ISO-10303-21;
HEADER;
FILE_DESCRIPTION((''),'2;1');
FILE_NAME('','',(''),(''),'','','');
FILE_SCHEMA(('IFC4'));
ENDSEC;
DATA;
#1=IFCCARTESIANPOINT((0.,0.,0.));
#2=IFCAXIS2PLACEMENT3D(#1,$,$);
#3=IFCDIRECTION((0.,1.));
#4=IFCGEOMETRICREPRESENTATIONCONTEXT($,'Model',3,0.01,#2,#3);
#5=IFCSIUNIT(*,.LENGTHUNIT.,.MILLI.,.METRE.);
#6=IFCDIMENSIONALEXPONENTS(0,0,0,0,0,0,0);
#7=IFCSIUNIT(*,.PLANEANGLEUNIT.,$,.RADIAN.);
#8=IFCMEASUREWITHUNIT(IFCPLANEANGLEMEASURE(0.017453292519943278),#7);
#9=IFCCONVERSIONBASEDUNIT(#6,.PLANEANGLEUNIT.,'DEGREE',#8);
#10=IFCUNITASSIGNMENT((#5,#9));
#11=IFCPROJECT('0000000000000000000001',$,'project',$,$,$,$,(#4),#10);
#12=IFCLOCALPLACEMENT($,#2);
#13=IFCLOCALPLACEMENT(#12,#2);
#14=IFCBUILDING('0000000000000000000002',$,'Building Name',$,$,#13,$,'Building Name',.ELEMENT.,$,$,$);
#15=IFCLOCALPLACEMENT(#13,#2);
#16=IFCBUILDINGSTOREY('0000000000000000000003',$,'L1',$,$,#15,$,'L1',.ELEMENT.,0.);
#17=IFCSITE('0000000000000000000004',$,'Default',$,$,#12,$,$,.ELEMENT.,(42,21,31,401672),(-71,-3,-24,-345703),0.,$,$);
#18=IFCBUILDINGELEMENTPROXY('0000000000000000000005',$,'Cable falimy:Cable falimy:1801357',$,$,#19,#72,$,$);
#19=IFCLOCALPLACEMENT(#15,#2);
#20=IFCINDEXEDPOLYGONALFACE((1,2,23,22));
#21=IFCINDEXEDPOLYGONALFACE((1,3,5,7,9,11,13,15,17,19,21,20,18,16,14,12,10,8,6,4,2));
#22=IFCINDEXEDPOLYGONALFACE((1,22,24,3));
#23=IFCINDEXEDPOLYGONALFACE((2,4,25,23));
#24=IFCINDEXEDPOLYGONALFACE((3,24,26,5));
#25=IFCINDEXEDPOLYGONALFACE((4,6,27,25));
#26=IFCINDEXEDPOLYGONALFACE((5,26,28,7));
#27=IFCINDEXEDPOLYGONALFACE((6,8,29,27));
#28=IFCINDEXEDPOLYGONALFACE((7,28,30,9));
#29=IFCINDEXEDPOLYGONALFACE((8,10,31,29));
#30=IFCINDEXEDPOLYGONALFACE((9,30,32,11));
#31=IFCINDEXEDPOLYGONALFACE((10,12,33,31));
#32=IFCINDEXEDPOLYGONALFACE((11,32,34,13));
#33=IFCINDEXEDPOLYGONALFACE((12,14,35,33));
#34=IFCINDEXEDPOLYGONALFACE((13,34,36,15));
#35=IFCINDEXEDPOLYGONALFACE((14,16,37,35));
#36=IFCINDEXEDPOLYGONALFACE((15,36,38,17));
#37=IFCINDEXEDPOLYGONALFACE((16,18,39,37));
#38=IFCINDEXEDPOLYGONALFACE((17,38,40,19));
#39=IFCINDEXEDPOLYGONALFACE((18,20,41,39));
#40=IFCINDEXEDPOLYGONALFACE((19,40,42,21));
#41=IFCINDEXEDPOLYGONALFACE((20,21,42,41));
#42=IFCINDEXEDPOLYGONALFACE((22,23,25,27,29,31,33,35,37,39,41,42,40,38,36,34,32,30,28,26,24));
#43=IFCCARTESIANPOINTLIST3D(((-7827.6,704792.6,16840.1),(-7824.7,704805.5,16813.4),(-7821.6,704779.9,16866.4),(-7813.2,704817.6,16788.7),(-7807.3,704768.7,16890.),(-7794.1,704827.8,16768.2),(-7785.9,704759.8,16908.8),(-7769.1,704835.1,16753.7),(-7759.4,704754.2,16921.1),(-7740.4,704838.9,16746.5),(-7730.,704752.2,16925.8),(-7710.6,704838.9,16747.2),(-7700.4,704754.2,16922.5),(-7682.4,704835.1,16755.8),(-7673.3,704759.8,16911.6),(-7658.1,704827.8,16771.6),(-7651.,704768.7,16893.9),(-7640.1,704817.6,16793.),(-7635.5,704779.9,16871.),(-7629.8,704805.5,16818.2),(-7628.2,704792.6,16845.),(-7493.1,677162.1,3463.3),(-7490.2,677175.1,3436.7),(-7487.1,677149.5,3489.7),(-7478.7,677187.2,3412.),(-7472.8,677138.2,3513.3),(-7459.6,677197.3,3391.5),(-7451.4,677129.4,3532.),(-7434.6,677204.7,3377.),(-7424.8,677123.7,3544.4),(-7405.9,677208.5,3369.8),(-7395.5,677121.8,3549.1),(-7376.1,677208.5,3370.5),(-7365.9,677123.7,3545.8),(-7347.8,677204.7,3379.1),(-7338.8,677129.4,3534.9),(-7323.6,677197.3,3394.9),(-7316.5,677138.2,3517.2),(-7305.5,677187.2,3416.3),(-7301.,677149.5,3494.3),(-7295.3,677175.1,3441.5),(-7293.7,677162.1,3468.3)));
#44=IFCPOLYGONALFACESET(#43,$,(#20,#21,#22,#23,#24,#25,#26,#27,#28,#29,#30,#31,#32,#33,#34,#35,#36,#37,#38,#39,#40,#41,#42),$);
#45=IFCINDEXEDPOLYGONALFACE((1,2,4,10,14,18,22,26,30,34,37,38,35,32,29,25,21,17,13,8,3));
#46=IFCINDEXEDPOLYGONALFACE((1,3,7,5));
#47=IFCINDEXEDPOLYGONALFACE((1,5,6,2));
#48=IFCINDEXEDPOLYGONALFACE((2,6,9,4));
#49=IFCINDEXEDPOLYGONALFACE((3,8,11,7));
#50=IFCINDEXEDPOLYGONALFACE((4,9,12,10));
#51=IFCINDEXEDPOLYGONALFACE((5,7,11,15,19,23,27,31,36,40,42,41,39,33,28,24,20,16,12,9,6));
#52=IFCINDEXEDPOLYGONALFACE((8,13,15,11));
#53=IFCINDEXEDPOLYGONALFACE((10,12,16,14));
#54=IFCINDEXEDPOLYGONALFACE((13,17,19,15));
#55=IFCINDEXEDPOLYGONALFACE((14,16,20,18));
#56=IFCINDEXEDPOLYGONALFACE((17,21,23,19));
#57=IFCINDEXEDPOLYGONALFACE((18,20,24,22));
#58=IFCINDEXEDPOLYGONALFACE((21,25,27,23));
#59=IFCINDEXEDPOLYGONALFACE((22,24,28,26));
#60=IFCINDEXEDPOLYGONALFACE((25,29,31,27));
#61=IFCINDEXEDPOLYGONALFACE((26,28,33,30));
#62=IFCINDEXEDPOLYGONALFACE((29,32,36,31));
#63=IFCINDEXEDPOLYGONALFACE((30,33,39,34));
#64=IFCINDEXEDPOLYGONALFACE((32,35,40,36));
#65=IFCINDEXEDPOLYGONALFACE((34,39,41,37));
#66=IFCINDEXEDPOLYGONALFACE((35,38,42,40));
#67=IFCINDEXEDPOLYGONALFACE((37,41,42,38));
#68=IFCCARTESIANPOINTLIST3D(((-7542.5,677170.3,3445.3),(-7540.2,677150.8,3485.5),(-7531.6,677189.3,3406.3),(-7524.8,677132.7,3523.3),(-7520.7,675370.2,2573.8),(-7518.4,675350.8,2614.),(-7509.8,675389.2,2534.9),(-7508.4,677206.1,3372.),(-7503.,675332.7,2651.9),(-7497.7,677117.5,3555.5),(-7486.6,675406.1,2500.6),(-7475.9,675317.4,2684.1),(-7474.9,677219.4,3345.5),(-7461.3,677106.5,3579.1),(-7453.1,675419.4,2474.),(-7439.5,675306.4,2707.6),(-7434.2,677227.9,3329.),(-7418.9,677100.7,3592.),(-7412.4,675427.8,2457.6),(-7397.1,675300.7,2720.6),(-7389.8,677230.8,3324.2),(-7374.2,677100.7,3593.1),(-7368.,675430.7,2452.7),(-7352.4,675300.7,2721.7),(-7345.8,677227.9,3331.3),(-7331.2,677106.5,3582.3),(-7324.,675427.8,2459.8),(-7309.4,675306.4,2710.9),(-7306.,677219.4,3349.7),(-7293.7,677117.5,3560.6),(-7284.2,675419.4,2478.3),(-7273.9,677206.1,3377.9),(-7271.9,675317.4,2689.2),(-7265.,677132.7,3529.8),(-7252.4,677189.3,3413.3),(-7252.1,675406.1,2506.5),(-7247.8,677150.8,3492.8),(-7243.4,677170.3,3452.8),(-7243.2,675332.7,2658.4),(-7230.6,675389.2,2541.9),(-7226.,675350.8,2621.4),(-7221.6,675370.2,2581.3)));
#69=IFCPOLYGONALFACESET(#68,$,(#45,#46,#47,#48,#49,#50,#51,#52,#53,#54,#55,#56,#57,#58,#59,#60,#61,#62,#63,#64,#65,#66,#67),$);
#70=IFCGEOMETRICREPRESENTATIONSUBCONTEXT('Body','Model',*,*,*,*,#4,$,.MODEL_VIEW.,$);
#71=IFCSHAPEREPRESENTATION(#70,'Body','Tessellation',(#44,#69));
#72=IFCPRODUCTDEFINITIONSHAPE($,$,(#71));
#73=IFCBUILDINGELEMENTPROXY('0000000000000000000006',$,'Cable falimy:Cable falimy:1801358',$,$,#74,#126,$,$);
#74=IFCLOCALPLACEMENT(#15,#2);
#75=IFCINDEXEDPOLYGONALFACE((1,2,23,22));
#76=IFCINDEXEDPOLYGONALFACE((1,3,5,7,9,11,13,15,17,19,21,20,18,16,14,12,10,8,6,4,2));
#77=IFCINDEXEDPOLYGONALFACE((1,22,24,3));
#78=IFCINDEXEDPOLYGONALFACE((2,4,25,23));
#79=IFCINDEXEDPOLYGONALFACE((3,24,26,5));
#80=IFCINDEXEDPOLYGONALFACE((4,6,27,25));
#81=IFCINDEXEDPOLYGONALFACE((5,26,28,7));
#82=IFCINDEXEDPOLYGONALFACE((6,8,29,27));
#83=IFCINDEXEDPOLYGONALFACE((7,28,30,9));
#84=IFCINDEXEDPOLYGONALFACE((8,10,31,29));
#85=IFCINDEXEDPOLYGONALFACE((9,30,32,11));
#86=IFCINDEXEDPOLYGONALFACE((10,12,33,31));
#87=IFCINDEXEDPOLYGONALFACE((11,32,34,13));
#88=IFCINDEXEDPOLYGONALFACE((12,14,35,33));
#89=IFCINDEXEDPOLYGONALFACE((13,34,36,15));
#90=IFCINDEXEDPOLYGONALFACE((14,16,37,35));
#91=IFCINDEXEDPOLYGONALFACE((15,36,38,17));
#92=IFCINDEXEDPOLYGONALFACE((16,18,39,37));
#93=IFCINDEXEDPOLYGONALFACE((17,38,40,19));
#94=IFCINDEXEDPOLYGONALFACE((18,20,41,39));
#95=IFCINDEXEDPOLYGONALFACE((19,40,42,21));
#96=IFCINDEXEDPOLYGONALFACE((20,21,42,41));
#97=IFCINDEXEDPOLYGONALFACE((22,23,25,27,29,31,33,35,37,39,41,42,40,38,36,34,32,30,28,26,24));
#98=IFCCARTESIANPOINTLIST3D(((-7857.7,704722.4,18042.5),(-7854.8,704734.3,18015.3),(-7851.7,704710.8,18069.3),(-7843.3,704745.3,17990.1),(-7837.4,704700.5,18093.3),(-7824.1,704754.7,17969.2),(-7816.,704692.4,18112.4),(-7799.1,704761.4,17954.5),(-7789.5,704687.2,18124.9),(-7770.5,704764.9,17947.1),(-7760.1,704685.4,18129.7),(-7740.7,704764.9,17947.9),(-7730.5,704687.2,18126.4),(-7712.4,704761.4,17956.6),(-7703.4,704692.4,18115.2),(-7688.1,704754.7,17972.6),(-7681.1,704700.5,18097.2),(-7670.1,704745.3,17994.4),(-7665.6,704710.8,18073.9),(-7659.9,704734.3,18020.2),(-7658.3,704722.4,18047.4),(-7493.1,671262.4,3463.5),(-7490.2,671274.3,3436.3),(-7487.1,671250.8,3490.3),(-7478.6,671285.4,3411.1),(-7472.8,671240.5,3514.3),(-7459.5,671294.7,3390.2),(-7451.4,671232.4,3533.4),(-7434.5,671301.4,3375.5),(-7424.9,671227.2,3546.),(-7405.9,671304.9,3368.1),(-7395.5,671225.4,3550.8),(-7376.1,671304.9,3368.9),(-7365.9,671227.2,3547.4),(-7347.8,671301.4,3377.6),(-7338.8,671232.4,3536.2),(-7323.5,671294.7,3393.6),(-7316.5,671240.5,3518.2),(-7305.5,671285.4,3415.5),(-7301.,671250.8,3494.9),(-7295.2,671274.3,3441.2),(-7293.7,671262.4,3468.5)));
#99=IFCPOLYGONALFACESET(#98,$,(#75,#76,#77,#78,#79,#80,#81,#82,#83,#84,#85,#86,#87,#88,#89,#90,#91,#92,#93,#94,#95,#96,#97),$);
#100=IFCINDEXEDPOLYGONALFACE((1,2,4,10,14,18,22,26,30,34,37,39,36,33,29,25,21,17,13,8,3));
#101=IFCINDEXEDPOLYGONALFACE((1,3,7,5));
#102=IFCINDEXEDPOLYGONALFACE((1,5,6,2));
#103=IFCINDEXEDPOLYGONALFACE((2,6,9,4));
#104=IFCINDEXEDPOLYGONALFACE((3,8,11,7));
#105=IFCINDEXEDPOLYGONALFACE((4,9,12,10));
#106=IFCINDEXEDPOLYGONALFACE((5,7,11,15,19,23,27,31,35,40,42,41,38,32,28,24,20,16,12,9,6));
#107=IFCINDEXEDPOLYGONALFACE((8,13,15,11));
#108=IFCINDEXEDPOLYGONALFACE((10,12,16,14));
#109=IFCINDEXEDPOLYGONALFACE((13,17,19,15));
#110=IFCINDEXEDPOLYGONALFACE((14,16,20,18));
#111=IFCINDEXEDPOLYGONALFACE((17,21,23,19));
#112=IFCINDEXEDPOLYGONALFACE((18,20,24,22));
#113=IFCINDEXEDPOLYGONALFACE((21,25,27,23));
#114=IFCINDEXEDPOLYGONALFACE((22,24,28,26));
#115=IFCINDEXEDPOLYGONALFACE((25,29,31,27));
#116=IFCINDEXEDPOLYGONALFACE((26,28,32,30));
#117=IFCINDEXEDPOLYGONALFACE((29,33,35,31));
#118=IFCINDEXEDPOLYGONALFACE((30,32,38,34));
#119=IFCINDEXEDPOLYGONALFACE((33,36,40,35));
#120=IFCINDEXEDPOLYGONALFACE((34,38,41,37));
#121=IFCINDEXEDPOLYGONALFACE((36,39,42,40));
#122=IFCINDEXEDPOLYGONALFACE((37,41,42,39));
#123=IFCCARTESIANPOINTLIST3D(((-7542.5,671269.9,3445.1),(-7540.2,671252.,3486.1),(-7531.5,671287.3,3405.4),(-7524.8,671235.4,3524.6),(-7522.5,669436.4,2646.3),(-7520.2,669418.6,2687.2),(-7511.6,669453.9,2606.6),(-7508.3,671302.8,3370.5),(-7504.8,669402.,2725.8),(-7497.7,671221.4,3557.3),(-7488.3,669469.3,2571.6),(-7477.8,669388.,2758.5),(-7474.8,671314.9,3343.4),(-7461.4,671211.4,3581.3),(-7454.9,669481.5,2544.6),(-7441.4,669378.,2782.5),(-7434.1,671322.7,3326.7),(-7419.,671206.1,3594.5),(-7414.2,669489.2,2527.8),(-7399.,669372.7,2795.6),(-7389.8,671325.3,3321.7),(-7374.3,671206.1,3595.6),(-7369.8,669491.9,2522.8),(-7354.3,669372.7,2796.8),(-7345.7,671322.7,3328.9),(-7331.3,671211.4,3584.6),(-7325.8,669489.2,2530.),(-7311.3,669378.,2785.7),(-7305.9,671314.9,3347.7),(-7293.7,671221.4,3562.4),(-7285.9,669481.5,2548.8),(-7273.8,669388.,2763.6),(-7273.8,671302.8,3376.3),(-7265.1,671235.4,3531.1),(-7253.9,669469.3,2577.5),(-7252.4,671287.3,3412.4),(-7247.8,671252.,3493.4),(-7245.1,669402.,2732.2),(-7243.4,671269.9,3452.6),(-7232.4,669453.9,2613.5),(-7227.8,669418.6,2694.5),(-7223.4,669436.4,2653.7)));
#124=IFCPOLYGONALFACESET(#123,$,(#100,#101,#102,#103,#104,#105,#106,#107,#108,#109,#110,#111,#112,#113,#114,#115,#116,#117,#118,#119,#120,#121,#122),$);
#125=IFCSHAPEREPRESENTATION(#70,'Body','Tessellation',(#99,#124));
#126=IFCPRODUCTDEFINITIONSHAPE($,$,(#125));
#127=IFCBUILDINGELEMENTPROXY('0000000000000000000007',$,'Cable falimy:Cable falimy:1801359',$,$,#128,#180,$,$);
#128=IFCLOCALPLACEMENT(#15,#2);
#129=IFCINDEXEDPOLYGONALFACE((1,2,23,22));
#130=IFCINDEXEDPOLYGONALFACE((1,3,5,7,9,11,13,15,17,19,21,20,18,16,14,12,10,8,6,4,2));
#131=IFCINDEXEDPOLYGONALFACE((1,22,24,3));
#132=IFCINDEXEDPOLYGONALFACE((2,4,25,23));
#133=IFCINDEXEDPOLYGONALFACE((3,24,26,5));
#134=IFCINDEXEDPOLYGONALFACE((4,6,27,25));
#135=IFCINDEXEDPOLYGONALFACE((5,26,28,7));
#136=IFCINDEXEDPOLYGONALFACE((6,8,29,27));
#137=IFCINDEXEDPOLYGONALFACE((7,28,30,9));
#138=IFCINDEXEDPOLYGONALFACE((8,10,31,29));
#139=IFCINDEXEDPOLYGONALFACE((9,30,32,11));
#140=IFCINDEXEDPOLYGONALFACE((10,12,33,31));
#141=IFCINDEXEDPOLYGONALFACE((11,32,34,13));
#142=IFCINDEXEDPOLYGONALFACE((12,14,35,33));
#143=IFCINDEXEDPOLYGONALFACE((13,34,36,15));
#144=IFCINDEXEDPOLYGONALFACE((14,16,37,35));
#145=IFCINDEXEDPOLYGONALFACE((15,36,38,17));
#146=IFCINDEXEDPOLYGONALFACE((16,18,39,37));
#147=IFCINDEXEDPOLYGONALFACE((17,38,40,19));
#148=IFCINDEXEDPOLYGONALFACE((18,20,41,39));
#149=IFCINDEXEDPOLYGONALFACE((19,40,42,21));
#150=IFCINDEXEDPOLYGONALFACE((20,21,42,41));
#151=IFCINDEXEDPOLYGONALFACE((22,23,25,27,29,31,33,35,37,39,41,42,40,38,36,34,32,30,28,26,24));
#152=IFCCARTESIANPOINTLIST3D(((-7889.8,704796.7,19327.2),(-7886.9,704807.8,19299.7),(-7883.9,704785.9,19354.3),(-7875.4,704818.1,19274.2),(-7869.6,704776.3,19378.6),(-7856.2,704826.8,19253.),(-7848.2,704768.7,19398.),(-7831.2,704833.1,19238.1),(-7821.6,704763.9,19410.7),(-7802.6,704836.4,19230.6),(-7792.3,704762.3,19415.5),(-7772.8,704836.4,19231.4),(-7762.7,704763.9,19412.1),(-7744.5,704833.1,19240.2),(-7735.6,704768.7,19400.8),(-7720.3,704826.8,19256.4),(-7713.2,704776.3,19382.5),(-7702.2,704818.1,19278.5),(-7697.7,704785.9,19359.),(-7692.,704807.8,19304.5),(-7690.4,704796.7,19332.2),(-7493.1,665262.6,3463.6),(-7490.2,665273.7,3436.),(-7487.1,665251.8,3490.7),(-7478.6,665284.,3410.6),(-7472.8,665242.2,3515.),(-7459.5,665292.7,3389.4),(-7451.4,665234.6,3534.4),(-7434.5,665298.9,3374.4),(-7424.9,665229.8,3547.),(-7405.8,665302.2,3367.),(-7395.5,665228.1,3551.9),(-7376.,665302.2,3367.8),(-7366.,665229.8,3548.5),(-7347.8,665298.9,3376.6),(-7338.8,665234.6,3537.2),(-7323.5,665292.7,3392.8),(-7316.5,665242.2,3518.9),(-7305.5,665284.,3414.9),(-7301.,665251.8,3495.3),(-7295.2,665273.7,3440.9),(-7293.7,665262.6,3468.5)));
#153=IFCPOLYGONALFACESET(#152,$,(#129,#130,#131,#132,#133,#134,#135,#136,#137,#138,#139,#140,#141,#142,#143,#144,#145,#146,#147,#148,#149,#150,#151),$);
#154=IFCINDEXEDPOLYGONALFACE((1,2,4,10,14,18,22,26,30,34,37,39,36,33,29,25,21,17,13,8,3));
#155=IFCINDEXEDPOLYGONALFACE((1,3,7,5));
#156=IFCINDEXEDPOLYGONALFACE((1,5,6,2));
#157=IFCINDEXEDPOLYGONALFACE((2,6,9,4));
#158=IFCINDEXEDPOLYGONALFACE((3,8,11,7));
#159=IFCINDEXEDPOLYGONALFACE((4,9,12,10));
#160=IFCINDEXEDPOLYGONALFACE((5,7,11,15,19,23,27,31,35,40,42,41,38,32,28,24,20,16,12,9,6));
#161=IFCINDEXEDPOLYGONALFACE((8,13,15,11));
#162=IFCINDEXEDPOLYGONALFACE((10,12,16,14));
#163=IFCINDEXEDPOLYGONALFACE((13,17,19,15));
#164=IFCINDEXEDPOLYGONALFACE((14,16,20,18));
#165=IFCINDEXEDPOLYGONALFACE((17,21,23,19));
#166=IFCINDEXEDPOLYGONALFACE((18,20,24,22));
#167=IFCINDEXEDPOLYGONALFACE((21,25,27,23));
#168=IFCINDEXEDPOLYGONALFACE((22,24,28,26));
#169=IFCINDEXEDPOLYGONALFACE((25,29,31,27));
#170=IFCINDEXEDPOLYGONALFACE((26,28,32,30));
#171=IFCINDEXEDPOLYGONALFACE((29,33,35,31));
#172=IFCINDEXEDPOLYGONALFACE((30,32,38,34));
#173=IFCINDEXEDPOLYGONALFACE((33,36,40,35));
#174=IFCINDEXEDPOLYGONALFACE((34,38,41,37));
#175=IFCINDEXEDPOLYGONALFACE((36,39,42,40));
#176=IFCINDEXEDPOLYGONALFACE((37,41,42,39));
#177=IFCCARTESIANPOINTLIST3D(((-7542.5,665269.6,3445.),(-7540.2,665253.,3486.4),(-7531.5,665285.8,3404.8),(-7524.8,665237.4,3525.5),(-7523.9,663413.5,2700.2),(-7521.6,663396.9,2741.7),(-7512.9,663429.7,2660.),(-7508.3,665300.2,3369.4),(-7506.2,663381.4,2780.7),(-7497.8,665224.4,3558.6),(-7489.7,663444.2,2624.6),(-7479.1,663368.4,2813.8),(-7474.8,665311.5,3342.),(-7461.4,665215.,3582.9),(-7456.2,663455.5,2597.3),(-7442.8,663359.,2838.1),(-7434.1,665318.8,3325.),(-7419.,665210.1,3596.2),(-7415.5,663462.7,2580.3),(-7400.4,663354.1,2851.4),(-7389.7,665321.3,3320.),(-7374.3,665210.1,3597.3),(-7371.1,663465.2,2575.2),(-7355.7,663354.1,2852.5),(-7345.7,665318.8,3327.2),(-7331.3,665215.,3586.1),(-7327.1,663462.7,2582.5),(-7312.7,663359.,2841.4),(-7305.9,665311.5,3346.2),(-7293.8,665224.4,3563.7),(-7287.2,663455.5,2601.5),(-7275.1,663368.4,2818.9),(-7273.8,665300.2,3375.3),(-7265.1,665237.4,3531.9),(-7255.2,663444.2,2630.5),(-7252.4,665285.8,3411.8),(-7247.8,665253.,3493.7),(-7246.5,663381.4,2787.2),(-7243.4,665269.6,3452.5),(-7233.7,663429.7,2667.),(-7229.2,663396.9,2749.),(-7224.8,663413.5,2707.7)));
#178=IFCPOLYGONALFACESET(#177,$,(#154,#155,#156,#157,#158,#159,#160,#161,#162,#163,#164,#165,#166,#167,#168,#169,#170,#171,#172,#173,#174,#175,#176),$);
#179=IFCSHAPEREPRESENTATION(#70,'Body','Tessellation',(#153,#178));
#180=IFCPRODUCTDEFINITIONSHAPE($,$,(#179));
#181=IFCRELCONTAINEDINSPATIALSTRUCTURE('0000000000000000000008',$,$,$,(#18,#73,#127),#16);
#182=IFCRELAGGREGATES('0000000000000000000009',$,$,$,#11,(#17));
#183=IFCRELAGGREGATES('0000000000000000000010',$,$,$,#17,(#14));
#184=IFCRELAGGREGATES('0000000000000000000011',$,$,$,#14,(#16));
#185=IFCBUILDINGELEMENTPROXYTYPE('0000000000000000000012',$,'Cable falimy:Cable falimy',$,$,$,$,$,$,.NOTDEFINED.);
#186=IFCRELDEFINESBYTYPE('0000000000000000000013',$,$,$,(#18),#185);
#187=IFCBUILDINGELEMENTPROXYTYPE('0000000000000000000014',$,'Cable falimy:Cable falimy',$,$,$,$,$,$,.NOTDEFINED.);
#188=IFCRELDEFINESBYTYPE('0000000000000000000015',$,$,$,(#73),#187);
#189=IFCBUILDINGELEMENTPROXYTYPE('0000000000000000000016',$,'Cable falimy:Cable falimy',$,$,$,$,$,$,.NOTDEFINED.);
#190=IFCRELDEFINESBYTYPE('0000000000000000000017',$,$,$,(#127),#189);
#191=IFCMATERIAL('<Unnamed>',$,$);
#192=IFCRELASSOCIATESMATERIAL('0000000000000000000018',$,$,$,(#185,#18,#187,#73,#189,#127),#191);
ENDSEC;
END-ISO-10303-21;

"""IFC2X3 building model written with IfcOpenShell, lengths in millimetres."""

from ifc_helpers import new_model, entity, si_unit, converted_unit, direction, frame, frame_2d, origin, place, context, subcontext, project, spatial, circle, extrude, source, transform, mapped, material, type_object, type_shapes, element, save


model = new_model("IFC2X3")

# Units and contexts
model_context = context("Model", 3, precision=0.01, world=origin(), true_north=direction((0.0, 1.0)))
body_context = subcontext(model_context, "Body", "Model", "MODEL_VIEW")
ifc_project = project(units=[si_unit("LENGTHUNIT", "METRE", prefix="MILLI"), converted_unit("PLANEANGLEUNIT", "DEGREE", entity("IfcPlaneAngleMeasure", 0.017453292519943278), si_unit("PLANEANGLEUNIT", "RADIAN"), dimensions=[0, 0, 0, 0, 0, 0, 0])], contexts=[model_context])

# Site, building, storey
site_placement = place(None, origin())
site = spatial("IfcSite", under=ifc_project, at=site_placement, Name="Default", CompositionType="ELEMENT", RefLatitude=(42, 21, 31, 401672), RefLongitude=(-71, -3, -24, -345703), RefElevation=0.0)
building_placement = place(site_placement, origin())
building = spatial("IfcBuilding", under=site, at=building_placement, Name="Building Name", LongName="Building Name", CompositionType="ELEMENT")
storey_placement = place(building_placement, origin())
storey = spatial("IfcBuildingStorey", under=building, at=storey_placement, Name="L1", LongName="L1", CompositionType="ELEMENT", Elevation=0.0)

# Shared definitions
ifc_material = material(Name="<Unnamed>")

# Building element proxies
building_element_proxy_type_1 = type_object("IfcBuildingElementProxyType", Name="Cable falimy:Cable falimy", PredefinedType="NOTDEFINED", material=ifc_material)
shared_shape_1 = source(origin(), body_context, "Body", "SweptSolid", [
    extrude(circle(Radius=100.0, at=frame_2d((0.0, 0.0), x_axis=(1.0, 0.0))), frame((0.0, 0.0, 0.0), z_axis=(0.900015, 0.0, 0.43586), x_axis=(-0.43586, 0.0, 0.900015)), (0.0, 0.0, 1.0), 30700.0),
    extrude(circle(Radius=150.0, at=frame_2d((0.0, 0.0), x_axis=(1.0, 0.0))), frame((-1800.0, 0.0, -871.7), z_axis=(0.900015, 0.0, 0.43586), x_axis=(0.43586, 0.0, -0.900015)), (0.0, 0.0, 1.0), 2000.0),
])
type_shapes(building_element_proxy_type_1, [shared_shape_1])
proxy_1_placement = place(storey_placement, frame((-7393.2, 677165.4, 3459.1), z_axis=(-0.025001, 0.0, 0.999687), x_axis=(0.0, 1.0, 0.0)))
element("IfcBuildingElementProxy", 1, at=proxy_1_placement, inside=storey, type_object=building_element_proxy_type_1, material=ifc_material, Name="Cable falimy:Cable falimy:1801357", context=body_context, shape_type="MappedRepresentation", body=[
    mapped(shared_shape_1, transform((0.0, 0.0, 0.0), scale=1.0)),
])
building_element_proxy_type_2 = type_object("IfcBuildingElementProxyType", Name="Cable falimy:Cable falimy", PredefinedType="NOTDEFINED", material=ifc_material)
shared_shape_2 = source(origin(), body_context, "Body", "SweptSolid", [
    extrude(circle(Radius=100.0, at=frame_2d((0.0, 0.0), x_axis=(1.0, 0.0))), frame((0.0, 0.0, 0.0), z_axis=(0.916712, 0.0, 0.399549), x_axis=(-0.399549, 0.0, 0.916712)), (0.0, 0.0, 1.0), 36500.0),
    extrude(circle(Radius=150.0, at=frame_2d((0.0, 0.0), x_axis=(1.0, 0.0))), frame((-1833.4, 0.0, -799.1), z_axis=(0.916712, 0.0, 0.399549), x_axis=(0.399549, 0.0, -0.916712)), (0.0, 0.0, 1.0), 2000.0),
])
type_shapes(building_element_proxy_type_2, [shared_shape_2])
proxy_2_placement = place(storey_placement, frame((-7393.2, 671265.4, 3459.1), z_axis=(-0.025001, 0.0, 0.999687), x_axis=(0.0, 1.0, 0.0)))
element("IfcBuildingElementProxy", 2, at=proxy_2_placement, inside=storey, type_object=building_element_proxy_type_2, material=ifc_material, Name="Cable falimy:Cable falimy:1801358", context=body_context, shape_type="MappedRepresentation", body=[
    mapped(shared_shape_2, transform((0.0, 0.0, 0.0), scale=1.0)),
])
building_element_proxy_type_3 = type_object("IfcBuildingElementProxyType", Name="Cable falimy:Cable falimy", PredefinedType="NOTDEFINED", material=ifc_material)
shared_shape_3 = source(origin(), body_context, "Body", "SweptSolid", [
    extrude(circle(Radius=100.0, at=frame_2d((0.0, 0.0), x_axis=(1.0, 0.0))), frame((0.0, 0.0, 0.0), z_axis=(0.928031, 0.0, 0.372502), x_axis=(-0.372502, 0.0, 0.928031)), (0.0, 0.0, 1.0), 42600.0),
    extrude(circle(Radius=150.0, at=frame_2d((0.0, 0.0), x_axis=(1.0, 0.0))), frame((-1856.1, 0.0, -745.0), z_axis=(0.928031, 0.0, 0.372502), x_axis=(0.372502, 0.0, -0.928031)), (0.0, 0.0, 1.0), 2000.0),
])
type_shapes(building_element_proxy_type_3, [shared_shape_3])
proxy_3_placement = place(storey_placement, frame((-7393.2, 665265.4, 3459.1), z_axis=(-0.025001, 0.0, 0.999687), x_axis=(0.0, 1.0, 0.0)))
element("IfcBuildingElementProxy", 3, at=proxy_3_placement, inside=storey, type_object=building_element_proxy_type_3, material=ifc_material, Name="Cable falimy:Cable falimy:1801359", context=body_context, shape_type="MappedRepresentation", body=[
    mapped(shared_shape_3, transform((0.0, 0.0, 0.0), scale=1.0)),
])

save(model, "model.ifc")
